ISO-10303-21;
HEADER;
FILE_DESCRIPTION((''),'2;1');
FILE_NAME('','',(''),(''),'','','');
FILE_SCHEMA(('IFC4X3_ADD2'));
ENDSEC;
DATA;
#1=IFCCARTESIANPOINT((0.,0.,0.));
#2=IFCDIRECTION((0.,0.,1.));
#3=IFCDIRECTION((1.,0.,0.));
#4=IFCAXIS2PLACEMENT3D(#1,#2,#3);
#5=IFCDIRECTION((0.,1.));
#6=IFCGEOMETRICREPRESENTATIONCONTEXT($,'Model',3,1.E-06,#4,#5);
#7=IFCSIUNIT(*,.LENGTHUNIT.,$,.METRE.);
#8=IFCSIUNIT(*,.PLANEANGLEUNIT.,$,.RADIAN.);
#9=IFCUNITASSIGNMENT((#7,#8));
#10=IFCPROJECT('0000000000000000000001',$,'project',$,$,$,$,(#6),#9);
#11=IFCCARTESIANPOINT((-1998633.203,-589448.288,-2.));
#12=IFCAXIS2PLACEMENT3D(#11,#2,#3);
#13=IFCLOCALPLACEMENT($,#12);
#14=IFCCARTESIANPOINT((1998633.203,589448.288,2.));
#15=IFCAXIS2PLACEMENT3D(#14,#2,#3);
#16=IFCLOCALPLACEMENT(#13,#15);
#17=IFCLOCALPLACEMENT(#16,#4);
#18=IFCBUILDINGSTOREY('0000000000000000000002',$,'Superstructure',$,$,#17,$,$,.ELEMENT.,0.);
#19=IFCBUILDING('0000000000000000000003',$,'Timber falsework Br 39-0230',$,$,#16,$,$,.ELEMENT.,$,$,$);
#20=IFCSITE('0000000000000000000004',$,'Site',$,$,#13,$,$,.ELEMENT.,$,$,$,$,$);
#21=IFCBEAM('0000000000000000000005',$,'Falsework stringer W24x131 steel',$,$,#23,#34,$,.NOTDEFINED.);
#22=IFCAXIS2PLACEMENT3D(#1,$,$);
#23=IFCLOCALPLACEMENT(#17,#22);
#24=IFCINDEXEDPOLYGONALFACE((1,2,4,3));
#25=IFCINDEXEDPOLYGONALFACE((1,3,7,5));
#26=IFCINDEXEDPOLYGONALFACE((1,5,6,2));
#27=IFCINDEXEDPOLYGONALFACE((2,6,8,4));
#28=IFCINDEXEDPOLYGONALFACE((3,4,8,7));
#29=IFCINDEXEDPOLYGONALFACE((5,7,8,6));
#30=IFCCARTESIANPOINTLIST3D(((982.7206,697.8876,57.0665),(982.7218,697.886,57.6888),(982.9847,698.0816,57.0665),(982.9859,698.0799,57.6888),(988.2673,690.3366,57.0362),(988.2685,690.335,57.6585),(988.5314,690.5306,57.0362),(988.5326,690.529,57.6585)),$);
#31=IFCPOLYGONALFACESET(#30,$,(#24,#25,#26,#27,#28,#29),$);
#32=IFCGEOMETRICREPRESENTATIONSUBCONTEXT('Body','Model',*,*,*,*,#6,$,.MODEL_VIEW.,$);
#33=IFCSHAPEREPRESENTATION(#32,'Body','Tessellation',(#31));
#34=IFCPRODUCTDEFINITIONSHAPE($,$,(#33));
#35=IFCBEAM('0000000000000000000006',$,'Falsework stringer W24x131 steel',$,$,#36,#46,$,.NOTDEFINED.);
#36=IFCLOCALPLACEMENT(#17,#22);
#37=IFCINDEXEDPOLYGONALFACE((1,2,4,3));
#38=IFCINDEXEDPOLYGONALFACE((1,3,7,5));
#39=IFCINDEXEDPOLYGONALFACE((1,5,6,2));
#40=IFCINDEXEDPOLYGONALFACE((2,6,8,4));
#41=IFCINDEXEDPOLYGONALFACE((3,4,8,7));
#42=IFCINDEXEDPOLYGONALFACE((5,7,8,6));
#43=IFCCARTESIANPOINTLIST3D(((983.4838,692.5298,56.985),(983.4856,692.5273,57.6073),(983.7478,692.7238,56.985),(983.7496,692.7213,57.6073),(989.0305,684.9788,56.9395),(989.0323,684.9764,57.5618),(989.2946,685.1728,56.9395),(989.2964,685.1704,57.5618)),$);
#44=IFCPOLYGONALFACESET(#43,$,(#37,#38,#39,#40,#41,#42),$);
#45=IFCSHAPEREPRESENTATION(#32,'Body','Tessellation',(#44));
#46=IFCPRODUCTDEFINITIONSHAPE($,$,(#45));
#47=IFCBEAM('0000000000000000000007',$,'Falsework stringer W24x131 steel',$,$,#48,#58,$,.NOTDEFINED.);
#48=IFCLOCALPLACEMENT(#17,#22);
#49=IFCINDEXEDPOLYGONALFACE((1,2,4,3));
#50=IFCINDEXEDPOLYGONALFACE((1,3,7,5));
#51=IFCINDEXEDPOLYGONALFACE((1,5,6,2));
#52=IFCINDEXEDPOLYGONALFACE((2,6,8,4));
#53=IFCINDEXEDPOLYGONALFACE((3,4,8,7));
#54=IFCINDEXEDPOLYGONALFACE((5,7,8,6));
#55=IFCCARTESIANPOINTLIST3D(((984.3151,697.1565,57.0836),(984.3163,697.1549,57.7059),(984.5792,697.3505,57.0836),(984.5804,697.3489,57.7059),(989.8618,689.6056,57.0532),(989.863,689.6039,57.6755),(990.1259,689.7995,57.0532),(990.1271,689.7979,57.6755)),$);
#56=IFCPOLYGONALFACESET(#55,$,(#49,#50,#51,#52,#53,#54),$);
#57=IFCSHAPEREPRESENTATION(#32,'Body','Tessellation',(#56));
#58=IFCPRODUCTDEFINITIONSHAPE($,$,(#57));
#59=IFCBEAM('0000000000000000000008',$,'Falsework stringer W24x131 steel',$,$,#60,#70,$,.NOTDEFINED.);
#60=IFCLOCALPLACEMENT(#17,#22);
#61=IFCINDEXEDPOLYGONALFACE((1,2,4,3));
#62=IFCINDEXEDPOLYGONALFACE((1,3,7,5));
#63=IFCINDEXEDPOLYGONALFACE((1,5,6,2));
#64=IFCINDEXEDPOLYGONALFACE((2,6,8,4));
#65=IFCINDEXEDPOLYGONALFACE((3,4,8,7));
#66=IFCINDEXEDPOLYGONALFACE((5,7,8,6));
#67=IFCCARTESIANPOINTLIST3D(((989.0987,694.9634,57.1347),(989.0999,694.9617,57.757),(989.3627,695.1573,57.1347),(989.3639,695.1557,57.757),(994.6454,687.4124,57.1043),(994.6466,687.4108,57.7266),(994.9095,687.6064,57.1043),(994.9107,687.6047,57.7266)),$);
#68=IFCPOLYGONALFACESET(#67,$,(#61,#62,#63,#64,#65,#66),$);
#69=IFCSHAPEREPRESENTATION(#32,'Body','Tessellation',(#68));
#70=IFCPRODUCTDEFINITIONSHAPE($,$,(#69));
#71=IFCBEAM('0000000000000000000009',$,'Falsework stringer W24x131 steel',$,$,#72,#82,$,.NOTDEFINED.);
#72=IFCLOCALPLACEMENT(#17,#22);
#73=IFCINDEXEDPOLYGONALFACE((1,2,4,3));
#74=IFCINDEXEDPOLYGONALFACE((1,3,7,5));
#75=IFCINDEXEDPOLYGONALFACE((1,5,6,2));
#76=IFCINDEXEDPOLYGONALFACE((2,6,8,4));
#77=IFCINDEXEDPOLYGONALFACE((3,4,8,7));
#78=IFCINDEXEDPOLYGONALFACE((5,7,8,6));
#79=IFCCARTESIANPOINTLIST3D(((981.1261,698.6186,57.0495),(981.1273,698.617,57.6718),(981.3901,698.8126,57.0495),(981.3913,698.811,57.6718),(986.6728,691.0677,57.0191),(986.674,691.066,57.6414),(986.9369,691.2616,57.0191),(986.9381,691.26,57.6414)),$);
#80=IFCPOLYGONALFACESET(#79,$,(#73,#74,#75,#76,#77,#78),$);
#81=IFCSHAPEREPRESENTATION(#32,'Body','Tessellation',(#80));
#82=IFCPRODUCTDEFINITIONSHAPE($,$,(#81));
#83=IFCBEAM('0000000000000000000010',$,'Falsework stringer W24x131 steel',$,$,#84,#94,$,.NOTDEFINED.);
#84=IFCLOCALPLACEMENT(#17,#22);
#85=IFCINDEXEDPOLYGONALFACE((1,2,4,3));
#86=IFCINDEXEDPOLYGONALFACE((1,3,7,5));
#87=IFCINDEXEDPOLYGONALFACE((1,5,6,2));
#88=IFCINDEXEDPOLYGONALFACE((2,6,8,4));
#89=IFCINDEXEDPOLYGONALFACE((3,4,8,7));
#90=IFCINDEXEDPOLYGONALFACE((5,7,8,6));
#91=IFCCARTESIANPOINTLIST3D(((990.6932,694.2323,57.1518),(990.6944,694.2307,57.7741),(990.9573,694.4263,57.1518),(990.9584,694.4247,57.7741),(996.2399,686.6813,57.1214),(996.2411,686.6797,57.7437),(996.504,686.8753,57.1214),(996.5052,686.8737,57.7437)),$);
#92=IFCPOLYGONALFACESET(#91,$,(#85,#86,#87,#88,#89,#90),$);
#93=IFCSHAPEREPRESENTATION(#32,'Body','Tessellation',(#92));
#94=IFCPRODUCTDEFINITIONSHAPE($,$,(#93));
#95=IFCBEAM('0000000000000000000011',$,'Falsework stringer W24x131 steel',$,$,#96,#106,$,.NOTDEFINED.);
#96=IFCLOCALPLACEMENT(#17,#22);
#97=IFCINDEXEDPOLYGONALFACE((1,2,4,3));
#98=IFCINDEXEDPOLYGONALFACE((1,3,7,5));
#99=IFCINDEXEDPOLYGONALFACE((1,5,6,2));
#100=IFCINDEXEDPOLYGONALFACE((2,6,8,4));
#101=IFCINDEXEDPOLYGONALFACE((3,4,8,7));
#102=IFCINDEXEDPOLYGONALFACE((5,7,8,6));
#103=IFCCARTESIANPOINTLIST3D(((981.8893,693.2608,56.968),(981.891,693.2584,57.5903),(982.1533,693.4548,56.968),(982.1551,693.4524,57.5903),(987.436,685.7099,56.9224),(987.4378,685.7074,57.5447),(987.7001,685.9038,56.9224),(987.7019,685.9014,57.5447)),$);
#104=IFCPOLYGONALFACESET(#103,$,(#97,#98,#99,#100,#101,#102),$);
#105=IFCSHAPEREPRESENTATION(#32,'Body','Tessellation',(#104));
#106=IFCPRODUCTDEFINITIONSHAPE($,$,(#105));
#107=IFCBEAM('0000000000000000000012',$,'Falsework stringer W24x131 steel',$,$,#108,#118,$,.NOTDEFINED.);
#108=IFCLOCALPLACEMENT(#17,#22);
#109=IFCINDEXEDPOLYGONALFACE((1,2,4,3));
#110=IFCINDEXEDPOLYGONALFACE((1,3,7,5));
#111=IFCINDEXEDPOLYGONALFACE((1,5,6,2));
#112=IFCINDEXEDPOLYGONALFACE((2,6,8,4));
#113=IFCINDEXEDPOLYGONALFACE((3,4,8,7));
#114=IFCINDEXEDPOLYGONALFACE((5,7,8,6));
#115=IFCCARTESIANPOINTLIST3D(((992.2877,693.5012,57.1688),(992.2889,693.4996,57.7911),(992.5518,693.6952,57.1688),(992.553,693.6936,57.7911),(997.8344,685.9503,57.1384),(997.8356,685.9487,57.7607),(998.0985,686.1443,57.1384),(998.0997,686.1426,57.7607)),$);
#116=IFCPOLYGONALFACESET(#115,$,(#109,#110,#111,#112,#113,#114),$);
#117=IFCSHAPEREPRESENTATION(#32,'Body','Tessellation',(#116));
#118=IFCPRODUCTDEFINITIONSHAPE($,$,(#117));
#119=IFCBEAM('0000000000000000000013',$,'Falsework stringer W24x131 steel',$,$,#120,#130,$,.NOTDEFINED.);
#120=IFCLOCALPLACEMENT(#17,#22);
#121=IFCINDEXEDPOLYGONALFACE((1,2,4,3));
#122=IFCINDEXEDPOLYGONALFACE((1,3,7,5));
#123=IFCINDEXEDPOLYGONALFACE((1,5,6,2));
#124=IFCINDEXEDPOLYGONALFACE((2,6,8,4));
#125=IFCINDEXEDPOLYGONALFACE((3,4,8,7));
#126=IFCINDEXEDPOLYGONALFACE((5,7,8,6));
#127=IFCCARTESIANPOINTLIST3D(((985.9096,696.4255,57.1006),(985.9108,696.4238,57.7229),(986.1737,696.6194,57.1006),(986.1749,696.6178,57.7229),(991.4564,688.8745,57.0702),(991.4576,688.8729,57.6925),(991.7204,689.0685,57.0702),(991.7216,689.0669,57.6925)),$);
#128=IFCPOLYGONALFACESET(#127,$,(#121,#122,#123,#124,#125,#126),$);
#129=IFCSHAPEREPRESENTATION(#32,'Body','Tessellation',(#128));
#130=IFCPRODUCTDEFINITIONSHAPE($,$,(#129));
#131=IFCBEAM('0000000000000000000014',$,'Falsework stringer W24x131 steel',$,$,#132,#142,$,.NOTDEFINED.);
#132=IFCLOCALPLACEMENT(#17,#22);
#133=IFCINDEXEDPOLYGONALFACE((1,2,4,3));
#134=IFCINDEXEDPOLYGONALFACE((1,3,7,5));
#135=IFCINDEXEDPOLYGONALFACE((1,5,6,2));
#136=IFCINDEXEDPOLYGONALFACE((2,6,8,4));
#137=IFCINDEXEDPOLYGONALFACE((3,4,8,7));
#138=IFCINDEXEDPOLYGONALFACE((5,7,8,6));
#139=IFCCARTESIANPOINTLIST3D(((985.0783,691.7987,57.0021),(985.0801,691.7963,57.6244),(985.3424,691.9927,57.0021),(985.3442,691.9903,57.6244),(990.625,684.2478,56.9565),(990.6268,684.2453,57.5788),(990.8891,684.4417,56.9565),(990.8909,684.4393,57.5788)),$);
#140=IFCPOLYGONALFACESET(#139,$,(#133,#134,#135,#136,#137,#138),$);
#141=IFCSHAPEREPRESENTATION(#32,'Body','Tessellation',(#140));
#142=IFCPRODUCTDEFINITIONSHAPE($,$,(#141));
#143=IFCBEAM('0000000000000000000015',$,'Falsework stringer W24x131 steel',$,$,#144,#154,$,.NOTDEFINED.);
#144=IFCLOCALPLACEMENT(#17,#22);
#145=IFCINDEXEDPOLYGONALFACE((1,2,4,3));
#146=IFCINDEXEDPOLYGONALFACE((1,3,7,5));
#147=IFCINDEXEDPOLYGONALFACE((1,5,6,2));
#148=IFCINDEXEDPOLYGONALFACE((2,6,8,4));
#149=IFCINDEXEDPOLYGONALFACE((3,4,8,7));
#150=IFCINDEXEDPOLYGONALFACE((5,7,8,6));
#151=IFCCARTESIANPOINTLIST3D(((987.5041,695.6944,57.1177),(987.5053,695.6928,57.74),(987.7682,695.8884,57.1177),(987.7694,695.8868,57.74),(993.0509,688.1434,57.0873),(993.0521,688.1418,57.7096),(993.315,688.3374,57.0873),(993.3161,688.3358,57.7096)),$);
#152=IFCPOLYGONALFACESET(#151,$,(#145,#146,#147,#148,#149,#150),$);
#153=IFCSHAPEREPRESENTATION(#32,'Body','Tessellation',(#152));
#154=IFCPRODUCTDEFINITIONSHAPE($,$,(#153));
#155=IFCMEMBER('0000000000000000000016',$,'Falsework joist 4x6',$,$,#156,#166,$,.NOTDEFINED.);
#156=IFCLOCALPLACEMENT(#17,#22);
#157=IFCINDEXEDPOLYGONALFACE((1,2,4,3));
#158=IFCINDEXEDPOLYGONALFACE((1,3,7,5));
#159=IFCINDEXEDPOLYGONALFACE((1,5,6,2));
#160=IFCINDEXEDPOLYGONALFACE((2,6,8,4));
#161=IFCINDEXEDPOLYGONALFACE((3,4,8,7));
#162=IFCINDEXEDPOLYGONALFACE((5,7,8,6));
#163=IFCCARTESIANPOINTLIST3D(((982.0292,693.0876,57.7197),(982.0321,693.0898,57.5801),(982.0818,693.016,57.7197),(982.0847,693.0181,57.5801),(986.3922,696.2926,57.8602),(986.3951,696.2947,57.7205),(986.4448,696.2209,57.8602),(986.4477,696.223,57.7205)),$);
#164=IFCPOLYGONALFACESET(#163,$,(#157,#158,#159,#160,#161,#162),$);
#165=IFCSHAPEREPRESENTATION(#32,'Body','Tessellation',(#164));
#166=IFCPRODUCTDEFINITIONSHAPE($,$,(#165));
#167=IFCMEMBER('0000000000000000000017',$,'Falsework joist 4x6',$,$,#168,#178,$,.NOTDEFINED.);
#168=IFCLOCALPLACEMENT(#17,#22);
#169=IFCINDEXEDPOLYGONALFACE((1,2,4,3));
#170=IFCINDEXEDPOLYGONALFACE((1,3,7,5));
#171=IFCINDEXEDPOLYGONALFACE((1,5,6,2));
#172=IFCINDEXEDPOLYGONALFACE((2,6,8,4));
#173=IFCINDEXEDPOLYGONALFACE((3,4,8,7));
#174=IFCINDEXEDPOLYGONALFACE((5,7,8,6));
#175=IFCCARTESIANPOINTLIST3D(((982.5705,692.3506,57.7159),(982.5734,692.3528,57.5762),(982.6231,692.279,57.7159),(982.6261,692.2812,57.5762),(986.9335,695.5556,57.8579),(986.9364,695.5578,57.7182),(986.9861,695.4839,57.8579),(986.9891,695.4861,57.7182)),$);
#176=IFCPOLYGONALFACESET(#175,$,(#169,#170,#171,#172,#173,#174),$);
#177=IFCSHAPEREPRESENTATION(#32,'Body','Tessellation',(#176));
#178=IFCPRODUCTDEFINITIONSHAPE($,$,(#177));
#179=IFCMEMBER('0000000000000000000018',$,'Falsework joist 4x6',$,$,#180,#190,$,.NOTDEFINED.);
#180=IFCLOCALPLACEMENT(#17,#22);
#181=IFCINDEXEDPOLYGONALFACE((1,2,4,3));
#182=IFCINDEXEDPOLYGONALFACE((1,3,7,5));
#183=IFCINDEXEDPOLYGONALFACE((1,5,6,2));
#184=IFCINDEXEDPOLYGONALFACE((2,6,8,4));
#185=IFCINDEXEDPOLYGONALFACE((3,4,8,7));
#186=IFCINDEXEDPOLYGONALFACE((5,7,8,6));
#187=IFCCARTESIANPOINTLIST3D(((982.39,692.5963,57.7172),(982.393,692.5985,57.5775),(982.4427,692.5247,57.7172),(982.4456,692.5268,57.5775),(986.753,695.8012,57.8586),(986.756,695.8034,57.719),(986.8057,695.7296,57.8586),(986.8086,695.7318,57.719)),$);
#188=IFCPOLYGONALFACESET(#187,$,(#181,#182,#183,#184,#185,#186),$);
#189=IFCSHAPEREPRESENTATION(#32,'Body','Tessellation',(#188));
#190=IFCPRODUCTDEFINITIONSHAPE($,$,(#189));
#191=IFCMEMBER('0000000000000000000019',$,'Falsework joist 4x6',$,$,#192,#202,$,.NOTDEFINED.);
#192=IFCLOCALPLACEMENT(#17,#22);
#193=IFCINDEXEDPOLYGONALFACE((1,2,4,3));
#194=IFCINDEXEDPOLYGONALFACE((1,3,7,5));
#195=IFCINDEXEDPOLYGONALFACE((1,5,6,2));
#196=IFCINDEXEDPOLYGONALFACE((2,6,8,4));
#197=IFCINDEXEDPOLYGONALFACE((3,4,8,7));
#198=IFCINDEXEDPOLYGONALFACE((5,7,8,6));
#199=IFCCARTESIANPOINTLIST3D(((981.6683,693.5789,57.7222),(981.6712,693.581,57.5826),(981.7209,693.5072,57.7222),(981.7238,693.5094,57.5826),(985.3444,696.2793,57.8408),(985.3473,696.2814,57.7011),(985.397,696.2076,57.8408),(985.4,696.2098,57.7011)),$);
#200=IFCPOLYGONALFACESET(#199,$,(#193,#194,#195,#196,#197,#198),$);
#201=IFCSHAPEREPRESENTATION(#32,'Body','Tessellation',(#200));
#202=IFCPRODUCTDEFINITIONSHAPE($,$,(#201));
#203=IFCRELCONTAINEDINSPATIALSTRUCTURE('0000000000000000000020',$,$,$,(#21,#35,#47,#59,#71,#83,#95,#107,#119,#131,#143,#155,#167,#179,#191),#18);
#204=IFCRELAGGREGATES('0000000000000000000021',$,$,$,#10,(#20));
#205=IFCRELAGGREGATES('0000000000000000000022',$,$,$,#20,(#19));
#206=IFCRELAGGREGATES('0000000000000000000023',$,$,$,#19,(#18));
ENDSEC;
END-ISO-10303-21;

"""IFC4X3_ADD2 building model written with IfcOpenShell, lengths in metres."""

from ifc_helpers import new_model, si_unit, direction, frame, frame_2d, origin, origin_with_axes, place, context, subcontext, project, spatial, rectangle, extrude, element, save


model = new_model("IFC4X3_ADD2")

# Units and contexts
model_context = context("Model", 3, precision=1e-06, world=origin_with_axes(), true_north=direction((0.0, 1.0)))
body_context = subcontext(model_context, "Body", "Model", "MODEL_VIEW")
ifc_project = project(units=[si_unit("LENGTHUNIT", "METRE"), si_unit("PLANEANGLEUNIT", "RADIAN")], contexts=[model_context])

# Site, building, storey
site_placement = place(None, frame((-1998633.203, -589448.288, -2.0), z_axis=(0.0, 0.0, 1.0), x_axis=(1.0, 0.0, 0.0)))
site = spatial("IfcSite", under=ifc_project, at=site_placement, Name="Site", CompositionType="ELEMENT")
building_placement = place(site_placement, frame((1998633.203, 589448.288, 2.0), z_axis=(0.0, 0.0, 1.0), x_axis=(1.0, 0.0, 0.0)))
building = spatial("IfcBuilding", under=site, at=building_placement, Name="Timber falsework Br 39-0230", CompositionType="ELEMENT")
storey_placement = place(building_placement, origin_with_axes())
storey = spatial("IfcBuildingStorey", under=building, at=storey_placement, Name="Superstructure", CompositionType="ELEMENT", Elevation=0.0)

# Beams
beam_1_placement = place(storey_placement, frame((982.8526, 697.9846, 57.0665), z_axis=(0.59201, -0.805924, -0.003244), x_axis=(0.805928, 0.592013, 0.0)))
element("IfcBeam", 1, at=beam_1_placement, inside=storey, Name="Falsework stringer W24x131 steel", PredefinedType="NOTDEFINED", context=body_context, shape_type="SweptSolid", body=[
    extrude(rectangle(XDim=0.3277, YDim=0.6223, at=frame_2d((0.0, 0.3111))), origin(), (0.0, 0.0, 1.0), 9.3693),
])
beam_2_placement = place(storey_placement, frame((983.6158, 692.6268, 56.985), z_axis=(0.592006, -0.805919, -0.004862), x_axis=(0.805928, 0.592013, 0.0)))
element("IfcBeam", 2, at=beam_2_placement, inside=storey, Name="Falsework stringer W24x131 steel", PredefinedType="NOTDEFINED", context=body_context, shape_type="SweptSolid", body=[
    extrude(rectangle(XDim=0.3277, YDim=0.6223, at=frame_2d((0.0, 0.3111))), origin(), (0.0, 0.0, 1.0), 9.3694),
])
for number, where, z_axis, x_axis, name in (
    (3, (984.4471, 697.2535, 57.0836), (0.59201, -0.805924, -0.003244), (0.805928, 0.592013, 0.0), "Falsework stringer W24x131 steel"),
    (4, (989.2307, 695.0603, 57.1347), (0.59201, -0.805924, -0.003244), (0.805928, 0.592013, 0.0), "Falsework stringer W24x131 steel"),
):
    element("IfcBeam", number, at=place(storey_placement, frame(where, z_axis=z_axis, x_axis=x_axis)), inside=storey, Name=name, PredefinedType="NOTDEFINED", context=body_context, shape_type="SweptSolid", body=[
        extrude(rectangle(XDim=0.3277, YDim=0.6223, at=frame_2d((0.0, 0.3111))), origin(), (0.0, 0.0, 1.0), 9.3693),
    ])
beam_3_placement = place(storey_placement, frame((981.2581, 698.7156, 57.0495), z_axis=(0.59201, -0.805924, -0.003244), x_axis=(0.805928, 0.592013, 0.0)))
element("IfcBeam", 5, at=beam_3_placement, inside=storey, Name="Falsework stringer W24x131 steel", PredefinedType="NOTDEFINED", context=body_context, shape_type="SweptSolid", body=[
    extrude(rectangle(XDim=0.3277, YDim=0.6223, at=frame_2d((0.0, 0.3111))), origin(), (0.0, 0.0, 1.0), 9.3693),
])
beam_4_placement = place(storey_placement, frame((990.8252, 694.3293, 57.1518), z_axis=(0.59201, -0.805924, -0.003244), x_axis=(0.805928, 0.592013, 0.0)))
element("IfcBeam", 6, at=beam_4_placement, inside=storey, Name="Falsework stringer W24x131 steel", PredefinedType="NOTDEFINED", context=body_context, shape_type="SweptSolid", body=[
    extrude(rectangle(XDim=0.3277, YDim=0.6223, at=frame_2d((0.0, 0.3111))), origin(), (0.0, 0.0, 1.0), 9.3693),
])
beam_5_placement = place(storey_placement, frame((982.0213, 693.3578, 56.968), z_axis=(0.592006, -0.805919, -0.004862), x_axis=(0.805928, 0.592013, 0.0)))
element("IfcBeam", 7, at=beam_5_placement, inside=storey, Name="Falsework stringer W24x131 steel", PredefinedType="NOTDEFINED", context=body_context, shape_type="SweptSolid", body=[
    extrude(rectangle(XDim=0.3277, YDim=0.6223, at=frame_2d((0.0, 0.3111))), origin(), (0.0, 0.0, 1.0), 9.3694),
])
beam_6_placement = place(storey_placement, frame((992.4197, 693.5982, 57.1688), z_axis=(0.59201, -0.805924, -0.003244), x_axis=(0.805928, 0.592013, 0.0)))
element("IfcBeam", 8, at=beam_6_placement, inside=storey, Name="Falsework stringer W24x131 steel", PredefinedType="NOTDEFINED", context=body_context, shape_type="SweptSolid", body=[
    extrude(rectangle(XDim=0.3277, YDim=0.6223, at=frame_2d((0.0, 0.3111))), origin(), (0.0, 0.0, 1.0), 9.3693),
])
beam_7_placement = place(storey_placement, frame((986.0417, 696.5225, 57.1006), z_axis=(0.59201, -0.805924, -0.003244), x_axis=(0.805928, 0.592013, 0.0)))
element("IfcBeam", 9, at=beam_7_placement, inside=storey, Name="Falsework stringer W24x131 steel", PredefinedType="NOTDEFINED", context=body_context, shape_type="SweptSolid", body=[
    extrude(rectangle(XDim=0.3277, YDim=0.6223, at=frame_2d((0.0, 0.3111))), origin(), (0.0, 0.0, 1.0), 9.3693),
])
beam_8_placement = place(storey_placement, frame((985.2103, 691.8957, 57.0021), z_axis=(0.592006, -0.805919, -0.004862), x_axis=(0.805928, 0.592013, 0.0)))
element("IfcBeam", 10, at=beam_8_placement, inside=storey, Name="Falsework stringer W24x131 steel", PredefinedType="NOTDEFINED", context=body_context, shape_type="SweptSolid", body=[
    extrude(rectangle(XDim=0.3277, YDim=0.6223, at=frame_2d((0.0, 0.3111))), origin(), (0.0, 0.0, 1.0), 9.3694),
])
beam_9_placement = place(storey_placement, frame((987.6362, 695.7914, 57.1177), z_axis=(0.59201, -0.805924, -0.003244), x_axis=(0.805928, 0.592013, 0.0)))
element("IfcBeam", 11, at=beam_9_placement, inside=storey, Name="Falsework stringer W24x131 steel", PredefinedType="NOTDEFINED", context=body_context, shape_type="SweptSolid", body=[
    extrude(rectangle(XDim=0.3277, YDim=0.6223, at=frame_2d((0.0, 0.3111))), origin(), (0.0, 0.0, 1.0), 9.3693),
])

# Members
member_1_placement = place(storey_placement, frame((982.0584, 693.0539, 57.5801), z_axis=(0.805657, 0.591814, 0.025936), x_axis=(-0.592013, 0.805928, 0.0)))
element("IfcMember", 12, at=member_1_placement, inside=storey, Name="Falsework joist 4x6", PredefinedType="NOTDEFINED", context=body_context, shape_type="SweptSolid", body=[
    extrude(rectangle(XDim=0.0889, YDim=0.1397, at=frame_2d((0.0, 0.0698))), origin(), (0.0, 0.0, 1.0), 5.4155),
])
member_2_placement = place(storey_placement, frame((982.5997, 692.317, 57.5762), z_axis=(0.805651, 0.59181, 0.02622), x_axis=(-0.592013, 0.805928, 0.0)))
element("IfcMember", 13, at=member_2_placement, inside=storey, Name="Falsework joist 4x6", PredefinedType="NOTDEFINED", context=body_context, shape_type="SweptSolid", body=[
    extrude(rectangle(XDim=0.0889, YDim=0.1397, at=frame_2d((0.0, 0.0698))), origin(), (0.0, 0.0, 1.0), 5.4155),
])
member_3_placement = place(storey_placement, frame((982.4193, 692.5626, 57.5775), z_axis=(0.805653, 0.591811, 0.026125), x_axis=(-0.592013, 0.805928, 0.0)))
element("IfcMember", 14, at=member_3_placement, inside=storey, Name="Falsework joist 4x6", PredefinedType="NOTDEFINED", context=body_context, shape_type="SweptSolid", body=[
    extrude(rectangle(XDim=0.0889, YDim=0.1397, at=frame_2d((0.0, 0.0698))), origin(), (0.0, 0.0, 1.0), 5.4155),
])
member_4_placement = place(storey_placement, frame((981.6975, 693.5452, 57.5826), z_axis=(0.805656, 0.591813, 0.025984), x_axis=(-0.592013, 0.805928, 0.0)))
element("IfcMember", 15, at=member_4_placement, inside=storey, Name="Falsework joist 4x6", PredefinedType="NOTDEFINED", context=body_context, shape_type="SweptSolid", body=[
    extrude(rectangle(XDim=0.0889, YDim=0.1397, at=frame_2d((0.0, 0.0698))), origin(), (0.0, 0.0, 1.0), 4.5629),
])

save(model, "model.ifc")
